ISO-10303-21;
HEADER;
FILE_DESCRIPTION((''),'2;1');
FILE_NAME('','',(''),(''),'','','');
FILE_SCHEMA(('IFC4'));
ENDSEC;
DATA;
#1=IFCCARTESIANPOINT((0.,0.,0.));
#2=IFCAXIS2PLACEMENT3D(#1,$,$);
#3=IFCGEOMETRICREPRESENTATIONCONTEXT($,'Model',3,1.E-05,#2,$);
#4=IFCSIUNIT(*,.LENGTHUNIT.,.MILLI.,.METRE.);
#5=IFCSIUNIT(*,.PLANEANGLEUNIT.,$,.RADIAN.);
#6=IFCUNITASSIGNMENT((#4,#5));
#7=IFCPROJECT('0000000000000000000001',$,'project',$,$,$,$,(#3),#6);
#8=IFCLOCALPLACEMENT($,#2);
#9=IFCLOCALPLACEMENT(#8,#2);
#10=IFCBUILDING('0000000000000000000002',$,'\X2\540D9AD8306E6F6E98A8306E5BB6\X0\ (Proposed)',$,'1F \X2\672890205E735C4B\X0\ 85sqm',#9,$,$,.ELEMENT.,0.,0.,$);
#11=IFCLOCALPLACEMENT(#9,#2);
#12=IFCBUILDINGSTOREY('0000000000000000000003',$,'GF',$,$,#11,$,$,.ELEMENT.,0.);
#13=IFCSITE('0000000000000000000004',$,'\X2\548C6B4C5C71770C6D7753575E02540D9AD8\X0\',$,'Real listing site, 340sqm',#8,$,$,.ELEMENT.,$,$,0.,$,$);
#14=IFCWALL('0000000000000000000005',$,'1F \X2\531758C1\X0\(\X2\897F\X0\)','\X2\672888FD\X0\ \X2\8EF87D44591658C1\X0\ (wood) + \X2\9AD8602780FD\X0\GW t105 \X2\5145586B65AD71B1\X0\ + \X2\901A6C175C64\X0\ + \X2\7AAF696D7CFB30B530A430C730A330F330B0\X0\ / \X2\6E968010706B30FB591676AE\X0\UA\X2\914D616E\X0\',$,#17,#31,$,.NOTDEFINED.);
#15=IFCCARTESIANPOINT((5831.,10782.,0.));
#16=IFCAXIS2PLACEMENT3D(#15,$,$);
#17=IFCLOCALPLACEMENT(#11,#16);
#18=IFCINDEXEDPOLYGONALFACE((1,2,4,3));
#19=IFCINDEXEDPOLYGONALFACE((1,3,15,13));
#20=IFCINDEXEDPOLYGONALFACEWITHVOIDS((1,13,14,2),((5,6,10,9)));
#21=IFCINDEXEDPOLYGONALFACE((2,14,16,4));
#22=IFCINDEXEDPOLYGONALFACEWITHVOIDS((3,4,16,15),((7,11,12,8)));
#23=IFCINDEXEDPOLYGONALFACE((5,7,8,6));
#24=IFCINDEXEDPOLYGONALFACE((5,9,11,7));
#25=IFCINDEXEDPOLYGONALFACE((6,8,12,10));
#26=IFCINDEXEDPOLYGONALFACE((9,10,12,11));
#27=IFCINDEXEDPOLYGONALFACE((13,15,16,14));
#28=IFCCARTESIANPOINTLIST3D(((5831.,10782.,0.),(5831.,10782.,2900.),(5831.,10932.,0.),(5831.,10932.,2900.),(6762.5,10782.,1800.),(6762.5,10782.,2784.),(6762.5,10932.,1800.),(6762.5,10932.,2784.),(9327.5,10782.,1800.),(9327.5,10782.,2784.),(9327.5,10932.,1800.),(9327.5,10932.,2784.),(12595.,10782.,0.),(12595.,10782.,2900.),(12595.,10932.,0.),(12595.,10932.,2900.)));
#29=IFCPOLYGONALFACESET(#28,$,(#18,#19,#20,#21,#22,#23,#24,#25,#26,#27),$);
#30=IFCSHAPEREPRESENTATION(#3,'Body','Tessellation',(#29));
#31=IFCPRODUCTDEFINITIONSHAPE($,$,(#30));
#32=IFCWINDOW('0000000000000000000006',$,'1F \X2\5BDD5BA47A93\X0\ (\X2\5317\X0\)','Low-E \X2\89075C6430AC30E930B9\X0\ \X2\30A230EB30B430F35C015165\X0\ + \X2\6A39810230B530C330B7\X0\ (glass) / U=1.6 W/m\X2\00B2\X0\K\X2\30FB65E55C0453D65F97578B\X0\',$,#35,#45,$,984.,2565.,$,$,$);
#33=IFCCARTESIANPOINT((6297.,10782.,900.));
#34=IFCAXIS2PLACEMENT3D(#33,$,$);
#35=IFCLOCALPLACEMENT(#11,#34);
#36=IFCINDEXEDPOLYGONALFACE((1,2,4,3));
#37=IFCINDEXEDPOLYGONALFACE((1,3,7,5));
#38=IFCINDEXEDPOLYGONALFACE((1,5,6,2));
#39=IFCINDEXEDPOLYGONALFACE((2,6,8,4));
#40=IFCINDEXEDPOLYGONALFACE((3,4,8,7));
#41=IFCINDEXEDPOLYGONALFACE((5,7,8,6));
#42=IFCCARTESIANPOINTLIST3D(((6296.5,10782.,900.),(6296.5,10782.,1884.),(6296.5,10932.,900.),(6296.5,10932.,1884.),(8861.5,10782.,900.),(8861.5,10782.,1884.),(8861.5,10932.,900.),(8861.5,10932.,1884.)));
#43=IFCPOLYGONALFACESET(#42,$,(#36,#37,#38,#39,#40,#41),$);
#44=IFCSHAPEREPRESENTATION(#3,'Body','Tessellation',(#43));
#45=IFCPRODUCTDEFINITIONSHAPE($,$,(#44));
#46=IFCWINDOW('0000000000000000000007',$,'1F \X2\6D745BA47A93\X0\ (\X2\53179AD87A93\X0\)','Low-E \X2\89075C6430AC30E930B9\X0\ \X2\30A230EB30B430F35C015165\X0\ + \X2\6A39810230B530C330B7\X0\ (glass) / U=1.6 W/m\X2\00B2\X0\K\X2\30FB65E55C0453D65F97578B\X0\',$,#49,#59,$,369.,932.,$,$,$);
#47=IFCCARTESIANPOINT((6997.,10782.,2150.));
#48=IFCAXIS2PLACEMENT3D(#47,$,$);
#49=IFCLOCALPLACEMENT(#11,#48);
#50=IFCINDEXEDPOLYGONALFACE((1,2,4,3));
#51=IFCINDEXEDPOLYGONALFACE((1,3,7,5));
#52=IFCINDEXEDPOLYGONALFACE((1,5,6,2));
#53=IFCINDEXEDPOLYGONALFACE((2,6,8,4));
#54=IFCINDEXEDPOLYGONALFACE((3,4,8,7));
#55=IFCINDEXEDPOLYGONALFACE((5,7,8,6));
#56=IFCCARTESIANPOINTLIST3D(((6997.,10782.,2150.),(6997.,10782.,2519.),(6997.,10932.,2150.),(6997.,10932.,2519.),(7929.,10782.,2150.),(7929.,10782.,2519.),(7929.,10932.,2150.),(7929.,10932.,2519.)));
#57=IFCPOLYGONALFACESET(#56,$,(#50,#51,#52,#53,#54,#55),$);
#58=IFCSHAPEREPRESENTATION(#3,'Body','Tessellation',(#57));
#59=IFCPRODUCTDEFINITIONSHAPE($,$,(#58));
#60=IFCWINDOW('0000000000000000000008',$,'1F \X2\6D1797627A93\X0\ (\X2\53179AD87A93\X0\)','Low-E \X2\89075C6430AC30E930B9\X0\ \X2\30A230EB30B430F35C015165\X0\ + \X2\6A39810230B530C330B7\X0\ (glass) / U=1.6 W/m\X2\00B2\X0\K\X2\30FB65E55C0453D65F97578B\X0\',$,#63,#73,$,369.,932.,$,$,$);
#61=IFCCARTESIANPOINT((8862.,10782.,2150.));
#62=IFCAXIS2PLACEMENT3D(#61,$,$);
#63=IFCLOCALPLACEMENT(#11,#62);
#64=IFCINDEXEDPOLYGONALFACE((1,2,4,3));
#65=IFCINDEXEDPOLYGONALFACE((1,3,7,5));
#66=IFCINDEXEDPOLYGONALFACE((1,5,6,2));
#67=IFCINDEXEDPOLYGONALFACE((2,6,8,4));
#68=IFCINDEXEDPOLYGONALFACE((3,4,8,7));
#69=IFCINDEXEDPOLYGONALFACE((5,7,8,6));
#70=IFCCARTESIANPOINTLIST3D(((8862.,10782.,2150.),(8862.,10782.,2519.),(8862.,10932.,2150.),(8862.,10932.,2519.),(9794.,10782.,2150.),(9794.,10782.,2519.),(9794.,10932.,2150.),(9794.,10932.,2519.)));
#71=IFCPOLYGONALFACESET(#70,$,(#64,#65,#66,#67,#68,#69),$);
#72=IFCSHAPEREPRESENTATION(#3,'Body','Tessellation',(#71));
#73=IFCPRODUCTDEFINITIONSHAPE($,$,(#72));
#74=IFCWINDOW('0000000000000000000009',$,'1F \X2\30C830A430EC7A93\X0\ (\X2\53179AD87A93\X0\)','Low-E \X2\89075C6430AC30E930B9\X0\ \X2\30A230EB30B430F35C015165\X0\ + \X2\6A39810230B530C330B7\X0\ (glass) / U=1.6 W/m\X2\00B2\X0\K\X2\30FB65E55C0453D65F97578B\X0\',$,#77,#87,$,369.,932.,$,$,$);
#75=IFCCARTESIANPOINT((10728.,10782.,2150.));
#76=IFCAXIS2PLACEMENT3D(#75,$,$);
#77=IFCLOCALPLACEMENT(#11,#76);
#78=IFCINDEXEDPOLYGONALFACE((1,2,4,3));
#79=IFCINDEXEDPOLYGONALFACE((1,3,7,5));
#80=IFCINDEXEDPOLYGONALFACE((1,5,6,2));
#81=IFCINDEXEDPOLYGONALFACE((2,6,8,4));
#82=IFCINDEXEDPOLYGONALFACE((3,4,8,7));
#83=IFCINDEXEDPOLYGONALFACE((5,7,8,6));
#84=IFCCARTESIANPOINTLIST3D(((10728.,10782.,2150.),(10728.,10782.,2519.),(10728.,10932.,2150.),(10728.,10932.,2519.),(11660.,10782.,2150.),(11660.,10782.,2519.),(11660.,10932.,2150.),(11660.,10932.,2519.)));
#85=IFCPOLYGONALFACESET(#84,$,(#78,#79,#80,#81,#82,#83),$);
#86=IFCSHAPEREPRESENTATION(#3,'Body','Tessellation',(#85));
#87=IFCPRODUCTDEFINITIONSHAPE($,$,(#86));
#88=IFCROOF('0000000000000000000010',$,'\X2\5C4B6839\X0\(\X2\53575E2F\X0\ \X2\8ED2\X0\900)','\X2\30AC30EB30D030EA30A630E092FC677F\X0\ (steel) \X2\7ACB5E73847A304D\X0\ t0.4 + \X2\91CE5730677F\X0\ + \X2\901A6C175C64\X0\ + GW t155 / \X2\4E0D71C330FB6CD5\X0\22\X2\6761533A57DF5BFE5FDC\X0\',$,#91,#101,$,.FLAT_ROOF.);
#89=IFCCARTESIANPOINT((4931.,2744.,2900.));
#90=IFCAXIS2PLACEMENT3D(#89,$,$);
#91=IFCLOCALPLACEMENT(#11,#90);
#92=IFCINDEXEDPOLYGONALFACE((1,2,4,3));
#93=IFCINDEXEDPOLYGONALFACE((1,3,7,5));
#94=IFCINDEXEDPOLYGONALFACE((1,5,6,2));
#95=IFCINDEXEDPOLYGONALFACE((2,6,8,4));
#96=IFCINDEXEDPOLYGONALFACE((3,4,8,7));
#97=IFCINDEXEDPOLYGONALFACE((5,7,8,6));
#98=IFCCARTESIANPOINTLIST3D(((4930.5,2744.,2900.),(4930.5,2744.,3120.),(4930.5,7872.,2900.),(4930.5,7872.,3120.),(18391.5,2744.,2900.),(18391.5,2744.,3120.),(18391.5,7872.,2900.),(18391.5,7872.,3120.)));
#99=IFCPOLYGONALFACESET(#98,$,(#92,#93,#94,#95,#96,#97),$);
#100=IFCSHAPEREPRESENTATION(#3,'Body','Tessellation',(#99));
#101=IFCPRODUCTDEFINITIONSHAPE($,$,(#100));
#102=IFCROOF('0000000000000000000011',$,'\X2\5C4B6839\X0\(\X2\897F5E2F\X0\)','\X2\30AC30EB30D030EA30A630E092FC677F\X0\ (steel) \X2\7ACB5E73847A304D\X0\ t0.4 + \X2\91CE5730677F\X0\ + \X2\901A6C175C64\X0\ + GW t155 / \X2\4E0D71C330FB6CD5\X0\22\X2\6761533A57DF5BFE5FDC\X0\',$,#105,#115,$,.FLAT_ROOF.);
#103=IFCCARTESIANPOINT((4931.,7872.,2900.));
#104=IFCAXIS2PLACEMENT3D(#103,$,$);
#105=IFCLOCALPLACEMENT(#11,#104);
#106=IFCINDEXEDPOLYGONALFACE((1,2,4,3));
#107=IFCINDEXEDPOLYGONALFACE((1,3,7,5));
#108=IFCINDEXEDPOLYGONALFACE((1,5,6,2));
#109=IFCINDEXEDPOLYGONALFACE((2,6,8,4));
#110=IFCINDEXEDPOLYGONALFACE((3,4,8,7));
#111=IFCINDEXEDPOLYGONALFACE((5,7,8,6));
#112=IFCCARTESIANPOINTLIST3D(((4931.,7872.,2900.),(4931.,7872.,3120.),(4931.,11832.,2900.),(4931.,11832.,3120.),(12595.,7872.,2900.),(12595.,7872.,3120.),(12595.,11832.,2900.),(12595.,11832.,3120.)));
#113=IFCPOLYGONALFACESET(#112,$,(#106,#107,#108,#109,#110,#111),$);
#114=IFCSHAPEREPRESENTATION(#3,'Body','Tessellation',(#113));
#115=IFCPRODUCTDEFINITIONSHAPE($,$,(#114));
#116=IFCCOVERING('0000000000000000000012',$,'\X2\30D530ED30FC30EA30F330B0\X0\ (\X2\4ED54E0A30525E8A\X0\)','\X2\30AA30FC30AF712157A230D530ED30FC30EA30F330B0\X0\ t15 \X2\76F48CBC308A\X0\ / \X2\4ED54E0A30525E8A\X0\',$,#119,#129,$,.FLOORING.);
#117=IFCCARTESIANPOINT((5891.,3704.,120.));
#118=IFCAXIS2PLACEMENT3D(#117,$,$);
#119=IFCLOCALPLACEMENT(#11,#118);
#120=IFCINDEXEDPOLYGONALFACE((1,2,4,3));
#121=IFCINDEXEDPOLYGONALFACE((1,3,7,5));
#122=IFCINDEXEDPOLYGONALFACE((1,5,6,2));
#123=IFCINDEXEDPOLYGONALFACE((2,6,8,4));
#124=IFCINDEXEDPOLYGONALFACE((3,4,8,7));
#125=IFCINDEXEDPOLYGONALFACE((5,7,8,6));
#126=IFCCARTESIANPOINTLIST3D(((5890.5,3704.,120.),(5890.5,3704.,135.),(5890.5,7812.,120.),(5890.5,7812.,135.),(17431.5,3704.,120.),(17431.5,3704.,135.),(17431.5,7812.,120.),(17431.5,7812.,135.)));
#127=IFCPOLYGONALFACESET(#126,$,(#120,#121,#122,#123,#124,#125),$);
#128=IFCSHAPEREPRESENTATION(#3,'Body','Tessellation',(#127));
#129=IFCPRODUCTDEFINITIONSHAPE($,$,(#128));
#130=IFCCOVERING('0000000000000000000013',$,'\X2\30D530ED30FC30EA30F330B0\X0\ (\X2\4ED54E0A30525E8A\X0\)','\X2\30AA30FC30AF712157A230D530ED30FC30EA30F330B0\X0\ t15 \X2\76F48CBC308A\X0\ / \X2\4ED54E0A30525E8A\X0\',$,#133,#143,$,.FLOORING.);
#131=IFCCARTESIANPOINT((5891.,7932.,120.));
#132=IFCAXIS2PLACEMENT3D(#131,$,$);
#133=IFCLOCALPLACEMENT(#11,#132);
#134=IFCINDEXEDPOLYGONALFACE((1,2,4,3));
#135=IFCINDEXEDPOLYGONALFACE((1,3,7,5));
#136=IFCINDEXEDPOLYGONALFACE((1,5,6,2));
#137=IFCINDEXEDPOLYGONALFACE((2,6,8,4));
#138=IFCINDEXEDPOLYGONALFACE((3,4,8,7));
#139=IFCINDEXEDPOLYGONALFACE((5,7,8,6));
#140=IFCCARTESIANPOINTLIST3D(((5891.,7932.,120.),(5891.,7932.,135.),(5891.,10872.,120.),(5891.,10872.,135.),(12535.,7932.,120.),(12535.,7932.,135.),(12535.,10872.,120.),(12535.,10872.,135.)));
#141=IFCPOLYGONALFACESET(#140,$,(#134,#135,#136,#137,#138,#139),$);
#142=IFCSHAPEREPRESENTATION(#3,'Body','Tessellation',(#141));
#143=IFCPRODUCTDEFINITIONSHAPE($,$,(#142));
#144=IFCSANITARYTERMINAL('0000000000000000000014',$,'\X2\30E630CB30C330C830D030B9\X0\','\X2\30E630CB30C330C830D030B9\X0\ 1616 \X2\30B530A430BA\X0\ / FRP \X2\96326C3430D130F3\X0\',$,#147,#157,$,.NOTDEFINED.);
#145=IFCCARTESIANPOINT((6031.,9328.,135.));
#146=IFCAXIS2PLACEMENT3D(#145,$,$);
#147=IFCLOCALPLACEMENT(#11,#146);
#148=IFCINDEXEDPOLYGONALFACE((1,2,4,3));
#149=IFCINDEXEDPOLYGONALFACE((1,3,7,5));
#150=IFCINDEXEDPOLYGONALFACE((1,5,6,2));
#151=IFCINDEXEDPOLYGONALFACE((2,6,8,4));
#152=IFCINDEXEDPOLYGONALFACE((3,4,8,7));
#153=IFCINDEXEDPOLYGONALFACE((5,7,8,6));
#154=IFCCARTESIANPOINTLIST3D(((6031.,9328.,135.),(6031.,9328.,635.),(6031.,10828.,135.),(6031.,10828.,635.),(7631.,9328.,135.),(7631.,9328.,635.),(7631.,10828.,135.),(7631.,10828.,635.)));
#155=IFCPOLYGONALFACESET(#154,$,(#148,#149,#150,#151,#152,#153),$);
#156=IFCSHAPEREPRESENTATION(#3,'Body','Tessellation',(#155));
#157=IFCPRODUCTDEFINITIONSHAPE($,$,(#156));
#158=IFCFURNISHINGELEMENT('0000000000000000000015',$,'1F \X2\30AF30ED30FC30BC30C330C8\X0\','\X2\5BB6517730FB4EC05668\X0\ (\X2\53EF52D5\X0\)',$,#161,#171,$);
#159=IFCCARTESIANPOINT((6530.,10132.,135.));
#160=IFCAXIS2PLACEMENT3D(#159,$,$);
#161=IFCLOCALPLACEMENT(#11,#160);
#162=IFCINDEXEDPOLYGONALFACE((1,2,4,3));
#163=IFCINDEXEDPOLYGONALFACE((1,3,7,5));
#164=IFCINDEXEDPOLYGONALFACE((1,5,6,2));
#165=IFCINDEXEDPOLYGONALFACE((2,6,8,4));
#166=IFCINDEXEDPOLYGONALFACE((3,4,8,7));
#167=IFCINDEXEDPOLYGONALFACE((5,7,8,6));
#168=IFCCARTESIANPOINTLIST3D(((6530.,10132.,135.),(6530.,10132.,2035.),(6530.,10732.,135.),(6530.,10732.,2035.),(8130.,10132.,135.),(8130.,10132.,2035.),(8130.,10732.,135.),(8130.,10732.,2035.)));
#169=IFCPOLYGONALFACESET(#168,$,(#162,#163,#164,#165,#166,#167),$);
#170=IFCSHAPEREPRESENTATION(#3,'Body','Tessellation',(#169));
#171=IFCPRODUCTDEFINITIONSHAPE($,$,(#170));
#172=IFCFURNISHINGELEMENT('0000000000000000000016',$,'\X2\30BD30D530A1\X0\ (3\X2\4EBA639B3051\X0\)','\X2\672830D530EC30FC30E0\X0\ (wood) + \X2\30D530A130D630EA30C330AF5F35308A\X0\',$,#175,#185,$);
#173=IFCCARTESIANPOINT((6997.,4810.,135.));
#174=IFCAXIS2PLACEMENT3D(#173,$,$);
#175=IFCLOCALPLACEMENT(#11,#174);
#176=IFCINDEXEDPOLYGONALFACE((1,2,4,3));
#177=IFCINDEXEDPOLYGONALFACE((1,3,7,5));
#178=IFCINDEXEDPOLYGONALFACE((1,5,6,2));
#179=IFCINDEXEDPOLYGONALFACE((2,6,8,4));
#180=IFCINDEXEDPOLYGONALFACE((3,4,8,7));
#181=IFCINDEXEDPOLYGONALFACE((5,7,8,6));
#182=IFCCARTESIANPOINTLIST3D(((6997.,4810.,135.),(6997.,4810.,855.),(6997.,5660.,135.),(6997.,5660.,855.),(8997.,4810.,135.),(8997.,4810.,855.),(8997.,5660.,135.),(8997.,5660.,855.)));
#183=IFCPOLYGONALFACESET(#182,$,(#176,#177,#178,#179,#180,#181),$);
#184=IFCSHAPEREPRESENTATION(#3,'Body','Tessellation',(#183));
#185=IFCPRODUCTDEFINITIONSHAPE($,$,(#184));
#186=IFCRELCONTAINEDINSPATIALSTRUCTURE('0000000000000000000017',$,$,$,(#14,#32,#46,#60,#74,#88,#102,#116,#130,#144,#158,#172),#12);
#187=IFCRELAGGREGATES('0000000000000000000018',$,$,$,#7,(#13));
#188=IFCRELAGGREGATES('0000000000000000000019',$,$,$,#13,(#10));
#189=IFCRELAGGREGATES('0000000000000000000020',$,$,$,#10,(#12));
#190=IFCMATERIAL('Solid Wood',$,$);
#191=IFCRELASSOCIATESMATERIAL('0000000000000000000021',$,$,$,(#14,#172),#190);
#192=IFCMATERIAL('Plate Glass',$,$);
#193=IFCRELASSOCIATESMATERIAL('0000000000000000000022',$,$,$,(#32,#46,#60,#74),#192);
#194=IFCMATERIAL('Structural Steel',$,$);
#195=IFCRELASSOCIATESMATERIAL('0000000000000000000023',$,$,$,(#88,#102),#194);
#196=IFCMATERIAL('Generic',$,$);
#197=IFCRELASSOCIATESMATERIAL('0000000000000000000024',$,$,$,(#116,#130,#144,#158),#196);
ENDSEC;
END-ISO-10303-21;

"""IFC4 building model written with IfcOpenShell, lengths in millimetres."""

from ifc_helpers import new_model, si_unit, frame, frame_2d, origin, place, context, project, spatial, rectangle, extrude, material, element, fill, save


model = new_model("IFC4")

# Units and contexts
model_context = context("Model", 3, precision=1e-05, world=origin())
ifc_project = project(units=[si_unit("LENGTHUNIT", "METRE", prefix="MILLI"), si_unit("PLANEANGLEUNIT", "RADIAN")], contexts=[model_context])

# Site, building, storey
site_placement = place(None, origin())
site = spatial("IfcSite", under=ifc_project, at=site_placement, Name="和歌山県海南市名高", ObjectType="Real listing site, 340sqm", CompositionType="ELEMENT", RefElevation=0.0)
building_placement = place(site_placement, origin())
building = spatial("IfcBuilding", under=site, at=building_placement, Name="名高の潮風の家 (Proposed)", ObjectType="1F 木造平屋 85sqm", CompositionType="ELEMENT", ElevationOfRefHeight=0.0, ElevationOfTerrain=0.0)
storey_placement = place(building_placement, origin())
storey = spatial("IfcBuildingStorey", under=building, at=storey_placement, Name="GF", CompositionType="ELEMENT", Elevation=0.0)

# Shared definitions
ifc_material_1 = material(Name="Solid Wood")

# Shared definitions
ifc_material_2 = material(Name="Plate Glass")

# Wall, openings, windows
wall_1_placement = place(storey_placement, frame((5831.0, 10782.0, 0.0)))
wall_1 = element("IfcWall", 1, at=wall_1_placement, inside=storey, material=ifc_material_1, Name="1F 北壁(西)", Description="木製 軸組外壁 (wood) + 高性能GW t105 充填断熱 + 通気層 + 窯業系サイディング / 準耐火・外皮UA配慮", PredefinedType="NOTDEFINED", context=model_context, shape_type="SweptSolid", body=[
    extrude(rectangle(XDim=6764.0, YDim=150.0, at=frame_2d((3382.0, 75.0))), frame((5831.0, 10782.0, 0.0)), (0.0, 0.0, 1.0), 2900.0),
])
opening_1_placement = place(storey_placement, frame((6297.0, 10782.0, 900.0)))
opening_1 = element("IfcOpeningElement", 2, at=opening_1_placement, cuts=wall_1, PredefinedType="NOTDEFINED", context=model_context, shape_type="SweptSolid", body=[
    extrude(rectangle(XDim=2565.0, YDim=150.0, at=frame_2d((1282.0, 75.0))), frame((6297.0, 10782.0, 900.0)), (0.0, 0.0, 1.0), 984.0),
])
opening_2_placement = place(storey_placement, frame((6997.0, 10782.0, 2150.0)))
opening_2 = element("IfcOpeningElement", 3, at=opening_2_placement, cuts=wall_1, PredefinedType="NOTDEFINED", context=model_context, shape_type="SweptSolid", body=[
    extrude(rectangle(XDim=932.0, YDim=150.0, at=frame_2d((466.0, 75.0))), frame((6997.0, 10782.0, 2150.0)), (0.0, 0.0, 1.0), 369.0),
])
opening_3_placement = place(storey_placement, frame((8862.0, 10782.0, 2150.0)))
opening_3 = element("IfcOpeningElement", 4, at=opening_3_placement, cuts=wall_1, PredefinedType="NOTDEFINED", context=model_context, shape_type="SweptSolid", body=[
    extrude(rectangle(XDim=932.0, YDim=150.0, at=frame_2d((466.0, 75.0))), frame((8862.0, 10782.0, 2150.0)), (0.0, 0.0, 1.0), 369.0),
])
opening_4_placement = place(storey_placement, frame((10728.0, 10782.0, 2150.0)))
opening_4 = element("IfcOpeningElement", 5, at=opening_4_placement, cuts=wall_1, PredefinedType="NOTDEFINED", context=model_context, shape_type="SweptSolid", body=[
    extrude(rectangle(XDim=932.0, YDim=150.0, at=frame_2d((466.0, 75.0))), frame((10728.0, 10782.0, 2150.0)), (0.0, 0.0, 1.0), 369.0),
])
window_1_placement = place(storey_placement, frame((6297.0, 10782.0, 900.0)))
window_1 = element("IfcWindow", 6, at=window_1_placement, inside=storey, material=ifc_material_2, Name="1F 寝室窓 (北)", Description="Low-E 複層ガラス アルゴン封入 + 樹脂サッシ (glass) / U=1.6 W/m²K・日射取得型", OverallHeight=984.0, OverallWidth=2565.0, context=model_context, shape_type="SweptSolid", body=[
    extrude(rectangle(XDim=2565.0, YDim=150.0, at=frame_2d((1282.0, 75.0))), frame((6297.0, 10782.0, 900.0)), (0.0, 0.0, 1.0), 984.0),
])
fill(opening_1, window_1)
window_2_placement = place(storey_placement, frame((6997.0, 10782.0, 2150.0)))
window_2 = element("IfcWindow", 7, at=window_2_placement, inside=storey, material=ifc_material_2, Name="1F 浴室窓 (北高窓)", Description="Low-E 複層ガラス アルゴン封入 + 樹脂サッシ (glass) / U=1.6 W/m²K・日射取得型", OverallHeight=369.0, OverallWidth=932.0, context=model_context, shape_type="SweptSolid", body=[
    extrude(rectangle(XDim=932.0, YDim=150.0, at=frame_2d((466.0, 75.0))), frame((6997.0, 10782.0, 2150.0)), (0.0, 0.0, 1.0), 369.0),
])
fill(opening_2, window_2)
window_3_placement = place(storey_placement, frame((8862.0, 10782.0, 2150.0)))
window_3 = element("IfcWindow", 8, at=window_3_placement, inside=storey, material=ifc_material_2, Name="1F 洗面窓 (北高窓)", Description="Low-E 複層ガラス アルゴン封入 + 樹脂サッシ (glass) / U=1.6 W/m²K・日射取得型", OverallHeight=369.0, OverallWidth=932.0, context=model_context, shape_type="SweptSolid", body=[
    extrude(rectangle(XDim=932.0, YDim=150.0, at=frame_2d((466.0, 75.0))), frame((8862.0, 10782.0, 2150.0)), (0.0, 0.0, 1.0), 369.0),
])
fill(opening_3, window_3)
window_4_placement = place(storey_placement, frame((10728.0, 10782.0, 2150.0)))
window_4 = element("IfcWindow", 9, at=window_4_placement, inside=storey, material=ifc_material_2, Name="1F トイレ窓 (北高窓)", Description="Low-E 複層ガラス アルゴン封入 + 樹脂サッシ (glass) / U=1.6 W/m²K・日射取得型", OverallHeight=369.0, OverallWidth=932.0, context=model_context, shape_type="SweptSolid", body=[
    extrude(rectangle(XDim=932.0, YDim=150.0, at=frame_2d((466.0, 75.0))), frame((10728.0, 10782.0, 2150.0)), (0.0, 0.0, 1.0), 369.0),
])
fill(opening_4, window_4)

# Roofs
ifc_material_3 = material(Name="Structural Steel")
roof_1_placement = place(storey_placement, frame((4931.0, 2744.0, 2900.0)))
element("IfcRoof", 10, at=roof_1_placement, inside=storey, material=ifc_material_3, Name="屋根(南帯 軒900)", Description="ガルバリウム鋼板 (steel) 立平葺き t0.4 + 野地板 + 通気層 + GW t155 / 不燃・法22条区域対応", PredefinedType="FLAT_ROOF", context=model_context, shape_type="SweptSolid", body=[
    extrude(rectangle(XDim=13461.0, YDim=5128.0, at=frame_2d((6730.0, 2564.0))), frame((4931.0, 2744.0, 2900.0)), (0.0, 0.0, 1.0), 220.0),
])
roof_2_placement = place(storey_placement, frame((4931.0, 7872.0, 2900.0)))
element("IfcRoof", 11, at=roof_2_placement, inside=storey, material=ifc_material_3, Name="屋根(西帯)", Description="ガルバリウム鋼板 (steel) 立平葺き t0.4 + 野地板 + 通気層 + GW t155 / 不燃・法22条区域対応", PredefinedType="FLAT_ROOF", context=model_context, shape_type="SweptSolid", body=[
    extrude(rectangle(XDim=7664.0, YDim=3960.0, at=frame_2d((3832.0, 1980.0))), frame((4931.0, 7872.0, 2900.0)), (0.0, 0.0, 1.0), 220.0),
])

# Coverings
ifc_material_4 = material(Name="Generic")
covering_1_placement = place(storey_placement, frame((5891.0, 3704.0, 120.0)))
element("IfcCovering", 12, at=covering_1_placement, inside=storey, material=ifc_material_4, Name="フローリング (仕上げ床)", Description="オーク無垢フローリング t15 直貼り / 仕上げ床", PredefinedType="FLOORING", context=model_context, shape_type="SweptSolid", body=[
    extrude(rectangle(XDim=11541.0, YDim=4108.0, at=frame_2d((5770.0, 2054.0))), frame((5891.0, 3704.0, 120.0)), (0.0, 0.0, 1.0), 15.0),
])
covering_2_placement = place(storey_placement, frame((5891.0, 7932.0, 120.0)))
element("IfcCovering", 13, at=covering_2_placement, inside=storey, material=ifc_material_4, Name="フローリング (仕上げ床)", Description="オーク無垢フローリング t15 直貼り / 仕上げ床", PredefinedType="FLOORING", context=model_context, shape_type="SweptSolid", body=[
    extrude(rectangle(XDim=6644.0, YDim=2940.0, at=frame_2d((3322.0, 1470.0))), frame((5891.0, 7932.0, 120.0)), (0.0, 0.0, 1.0), 15.0),
])

# Sanitary terminal
sanitary_terminal_placement = place(storey_placement, frame((6031.0, 9328.0, 135.0)))
element("IfcSanitaryTerminal", 14, at=sanitary_terminal_placement, inside=storey, material=ifc_material_4, Name="ユニットバス", Description="ユニットバス 1616 サイズ / FRP 防水パン", PredefinedType="NOTDEFINED", context=model_context, shape_type="SweptSolid", body=[
    extrude(rectangle(XDim=1600.0, YDim=1500.0, at=frame_2d((800.0, 750.0))), frame((6031.0, 9328.0, 135.0)), (0.0, 0.0, 1.0), 500.0),
])

# Furnishing elements
furnishing_1_placement = place(storey_placement, frame((6530.0, 10132.0, 135.0)))
element("IfcFurnishingElement", 15, at=furnishing_1_placement, inside=storey, material=ifc_material_4, Name="1F クローゼット", Description="家具・什器 (可動)", context=model_context, shape_type="SweptSolid", body=[
    extrude(rectangle(XDim=1600.0, YDim=600.0, at=frame_2d((800.0, 300.0))), frame((6530.0, 10132.0, 135.0)), (0.0, 0.0, 1.0), 1900.0),
])
furnishing_2_placement = place(storey_placement, frame((6997.0, 4810.0, 135.0)))
element("IfcFurnishingElement", 16, at=furnishing_2_placement, inside=storey, material=ifc_material_1, Name="ソファ (3人掛け)", Description="木フレーム (wood) + ファブリック張り", context=model_context, shape_type="SweptSolid", body=[
    extrude(rectangle(XDim=2000.0, YDim=850.0, at=frame_2d((1000.0, 425.0))), frame((6997.0, 4810.0, 135.0)), (0.0, 0.0, 1.0), 720.0),
])

save(model, "model.ifc")
